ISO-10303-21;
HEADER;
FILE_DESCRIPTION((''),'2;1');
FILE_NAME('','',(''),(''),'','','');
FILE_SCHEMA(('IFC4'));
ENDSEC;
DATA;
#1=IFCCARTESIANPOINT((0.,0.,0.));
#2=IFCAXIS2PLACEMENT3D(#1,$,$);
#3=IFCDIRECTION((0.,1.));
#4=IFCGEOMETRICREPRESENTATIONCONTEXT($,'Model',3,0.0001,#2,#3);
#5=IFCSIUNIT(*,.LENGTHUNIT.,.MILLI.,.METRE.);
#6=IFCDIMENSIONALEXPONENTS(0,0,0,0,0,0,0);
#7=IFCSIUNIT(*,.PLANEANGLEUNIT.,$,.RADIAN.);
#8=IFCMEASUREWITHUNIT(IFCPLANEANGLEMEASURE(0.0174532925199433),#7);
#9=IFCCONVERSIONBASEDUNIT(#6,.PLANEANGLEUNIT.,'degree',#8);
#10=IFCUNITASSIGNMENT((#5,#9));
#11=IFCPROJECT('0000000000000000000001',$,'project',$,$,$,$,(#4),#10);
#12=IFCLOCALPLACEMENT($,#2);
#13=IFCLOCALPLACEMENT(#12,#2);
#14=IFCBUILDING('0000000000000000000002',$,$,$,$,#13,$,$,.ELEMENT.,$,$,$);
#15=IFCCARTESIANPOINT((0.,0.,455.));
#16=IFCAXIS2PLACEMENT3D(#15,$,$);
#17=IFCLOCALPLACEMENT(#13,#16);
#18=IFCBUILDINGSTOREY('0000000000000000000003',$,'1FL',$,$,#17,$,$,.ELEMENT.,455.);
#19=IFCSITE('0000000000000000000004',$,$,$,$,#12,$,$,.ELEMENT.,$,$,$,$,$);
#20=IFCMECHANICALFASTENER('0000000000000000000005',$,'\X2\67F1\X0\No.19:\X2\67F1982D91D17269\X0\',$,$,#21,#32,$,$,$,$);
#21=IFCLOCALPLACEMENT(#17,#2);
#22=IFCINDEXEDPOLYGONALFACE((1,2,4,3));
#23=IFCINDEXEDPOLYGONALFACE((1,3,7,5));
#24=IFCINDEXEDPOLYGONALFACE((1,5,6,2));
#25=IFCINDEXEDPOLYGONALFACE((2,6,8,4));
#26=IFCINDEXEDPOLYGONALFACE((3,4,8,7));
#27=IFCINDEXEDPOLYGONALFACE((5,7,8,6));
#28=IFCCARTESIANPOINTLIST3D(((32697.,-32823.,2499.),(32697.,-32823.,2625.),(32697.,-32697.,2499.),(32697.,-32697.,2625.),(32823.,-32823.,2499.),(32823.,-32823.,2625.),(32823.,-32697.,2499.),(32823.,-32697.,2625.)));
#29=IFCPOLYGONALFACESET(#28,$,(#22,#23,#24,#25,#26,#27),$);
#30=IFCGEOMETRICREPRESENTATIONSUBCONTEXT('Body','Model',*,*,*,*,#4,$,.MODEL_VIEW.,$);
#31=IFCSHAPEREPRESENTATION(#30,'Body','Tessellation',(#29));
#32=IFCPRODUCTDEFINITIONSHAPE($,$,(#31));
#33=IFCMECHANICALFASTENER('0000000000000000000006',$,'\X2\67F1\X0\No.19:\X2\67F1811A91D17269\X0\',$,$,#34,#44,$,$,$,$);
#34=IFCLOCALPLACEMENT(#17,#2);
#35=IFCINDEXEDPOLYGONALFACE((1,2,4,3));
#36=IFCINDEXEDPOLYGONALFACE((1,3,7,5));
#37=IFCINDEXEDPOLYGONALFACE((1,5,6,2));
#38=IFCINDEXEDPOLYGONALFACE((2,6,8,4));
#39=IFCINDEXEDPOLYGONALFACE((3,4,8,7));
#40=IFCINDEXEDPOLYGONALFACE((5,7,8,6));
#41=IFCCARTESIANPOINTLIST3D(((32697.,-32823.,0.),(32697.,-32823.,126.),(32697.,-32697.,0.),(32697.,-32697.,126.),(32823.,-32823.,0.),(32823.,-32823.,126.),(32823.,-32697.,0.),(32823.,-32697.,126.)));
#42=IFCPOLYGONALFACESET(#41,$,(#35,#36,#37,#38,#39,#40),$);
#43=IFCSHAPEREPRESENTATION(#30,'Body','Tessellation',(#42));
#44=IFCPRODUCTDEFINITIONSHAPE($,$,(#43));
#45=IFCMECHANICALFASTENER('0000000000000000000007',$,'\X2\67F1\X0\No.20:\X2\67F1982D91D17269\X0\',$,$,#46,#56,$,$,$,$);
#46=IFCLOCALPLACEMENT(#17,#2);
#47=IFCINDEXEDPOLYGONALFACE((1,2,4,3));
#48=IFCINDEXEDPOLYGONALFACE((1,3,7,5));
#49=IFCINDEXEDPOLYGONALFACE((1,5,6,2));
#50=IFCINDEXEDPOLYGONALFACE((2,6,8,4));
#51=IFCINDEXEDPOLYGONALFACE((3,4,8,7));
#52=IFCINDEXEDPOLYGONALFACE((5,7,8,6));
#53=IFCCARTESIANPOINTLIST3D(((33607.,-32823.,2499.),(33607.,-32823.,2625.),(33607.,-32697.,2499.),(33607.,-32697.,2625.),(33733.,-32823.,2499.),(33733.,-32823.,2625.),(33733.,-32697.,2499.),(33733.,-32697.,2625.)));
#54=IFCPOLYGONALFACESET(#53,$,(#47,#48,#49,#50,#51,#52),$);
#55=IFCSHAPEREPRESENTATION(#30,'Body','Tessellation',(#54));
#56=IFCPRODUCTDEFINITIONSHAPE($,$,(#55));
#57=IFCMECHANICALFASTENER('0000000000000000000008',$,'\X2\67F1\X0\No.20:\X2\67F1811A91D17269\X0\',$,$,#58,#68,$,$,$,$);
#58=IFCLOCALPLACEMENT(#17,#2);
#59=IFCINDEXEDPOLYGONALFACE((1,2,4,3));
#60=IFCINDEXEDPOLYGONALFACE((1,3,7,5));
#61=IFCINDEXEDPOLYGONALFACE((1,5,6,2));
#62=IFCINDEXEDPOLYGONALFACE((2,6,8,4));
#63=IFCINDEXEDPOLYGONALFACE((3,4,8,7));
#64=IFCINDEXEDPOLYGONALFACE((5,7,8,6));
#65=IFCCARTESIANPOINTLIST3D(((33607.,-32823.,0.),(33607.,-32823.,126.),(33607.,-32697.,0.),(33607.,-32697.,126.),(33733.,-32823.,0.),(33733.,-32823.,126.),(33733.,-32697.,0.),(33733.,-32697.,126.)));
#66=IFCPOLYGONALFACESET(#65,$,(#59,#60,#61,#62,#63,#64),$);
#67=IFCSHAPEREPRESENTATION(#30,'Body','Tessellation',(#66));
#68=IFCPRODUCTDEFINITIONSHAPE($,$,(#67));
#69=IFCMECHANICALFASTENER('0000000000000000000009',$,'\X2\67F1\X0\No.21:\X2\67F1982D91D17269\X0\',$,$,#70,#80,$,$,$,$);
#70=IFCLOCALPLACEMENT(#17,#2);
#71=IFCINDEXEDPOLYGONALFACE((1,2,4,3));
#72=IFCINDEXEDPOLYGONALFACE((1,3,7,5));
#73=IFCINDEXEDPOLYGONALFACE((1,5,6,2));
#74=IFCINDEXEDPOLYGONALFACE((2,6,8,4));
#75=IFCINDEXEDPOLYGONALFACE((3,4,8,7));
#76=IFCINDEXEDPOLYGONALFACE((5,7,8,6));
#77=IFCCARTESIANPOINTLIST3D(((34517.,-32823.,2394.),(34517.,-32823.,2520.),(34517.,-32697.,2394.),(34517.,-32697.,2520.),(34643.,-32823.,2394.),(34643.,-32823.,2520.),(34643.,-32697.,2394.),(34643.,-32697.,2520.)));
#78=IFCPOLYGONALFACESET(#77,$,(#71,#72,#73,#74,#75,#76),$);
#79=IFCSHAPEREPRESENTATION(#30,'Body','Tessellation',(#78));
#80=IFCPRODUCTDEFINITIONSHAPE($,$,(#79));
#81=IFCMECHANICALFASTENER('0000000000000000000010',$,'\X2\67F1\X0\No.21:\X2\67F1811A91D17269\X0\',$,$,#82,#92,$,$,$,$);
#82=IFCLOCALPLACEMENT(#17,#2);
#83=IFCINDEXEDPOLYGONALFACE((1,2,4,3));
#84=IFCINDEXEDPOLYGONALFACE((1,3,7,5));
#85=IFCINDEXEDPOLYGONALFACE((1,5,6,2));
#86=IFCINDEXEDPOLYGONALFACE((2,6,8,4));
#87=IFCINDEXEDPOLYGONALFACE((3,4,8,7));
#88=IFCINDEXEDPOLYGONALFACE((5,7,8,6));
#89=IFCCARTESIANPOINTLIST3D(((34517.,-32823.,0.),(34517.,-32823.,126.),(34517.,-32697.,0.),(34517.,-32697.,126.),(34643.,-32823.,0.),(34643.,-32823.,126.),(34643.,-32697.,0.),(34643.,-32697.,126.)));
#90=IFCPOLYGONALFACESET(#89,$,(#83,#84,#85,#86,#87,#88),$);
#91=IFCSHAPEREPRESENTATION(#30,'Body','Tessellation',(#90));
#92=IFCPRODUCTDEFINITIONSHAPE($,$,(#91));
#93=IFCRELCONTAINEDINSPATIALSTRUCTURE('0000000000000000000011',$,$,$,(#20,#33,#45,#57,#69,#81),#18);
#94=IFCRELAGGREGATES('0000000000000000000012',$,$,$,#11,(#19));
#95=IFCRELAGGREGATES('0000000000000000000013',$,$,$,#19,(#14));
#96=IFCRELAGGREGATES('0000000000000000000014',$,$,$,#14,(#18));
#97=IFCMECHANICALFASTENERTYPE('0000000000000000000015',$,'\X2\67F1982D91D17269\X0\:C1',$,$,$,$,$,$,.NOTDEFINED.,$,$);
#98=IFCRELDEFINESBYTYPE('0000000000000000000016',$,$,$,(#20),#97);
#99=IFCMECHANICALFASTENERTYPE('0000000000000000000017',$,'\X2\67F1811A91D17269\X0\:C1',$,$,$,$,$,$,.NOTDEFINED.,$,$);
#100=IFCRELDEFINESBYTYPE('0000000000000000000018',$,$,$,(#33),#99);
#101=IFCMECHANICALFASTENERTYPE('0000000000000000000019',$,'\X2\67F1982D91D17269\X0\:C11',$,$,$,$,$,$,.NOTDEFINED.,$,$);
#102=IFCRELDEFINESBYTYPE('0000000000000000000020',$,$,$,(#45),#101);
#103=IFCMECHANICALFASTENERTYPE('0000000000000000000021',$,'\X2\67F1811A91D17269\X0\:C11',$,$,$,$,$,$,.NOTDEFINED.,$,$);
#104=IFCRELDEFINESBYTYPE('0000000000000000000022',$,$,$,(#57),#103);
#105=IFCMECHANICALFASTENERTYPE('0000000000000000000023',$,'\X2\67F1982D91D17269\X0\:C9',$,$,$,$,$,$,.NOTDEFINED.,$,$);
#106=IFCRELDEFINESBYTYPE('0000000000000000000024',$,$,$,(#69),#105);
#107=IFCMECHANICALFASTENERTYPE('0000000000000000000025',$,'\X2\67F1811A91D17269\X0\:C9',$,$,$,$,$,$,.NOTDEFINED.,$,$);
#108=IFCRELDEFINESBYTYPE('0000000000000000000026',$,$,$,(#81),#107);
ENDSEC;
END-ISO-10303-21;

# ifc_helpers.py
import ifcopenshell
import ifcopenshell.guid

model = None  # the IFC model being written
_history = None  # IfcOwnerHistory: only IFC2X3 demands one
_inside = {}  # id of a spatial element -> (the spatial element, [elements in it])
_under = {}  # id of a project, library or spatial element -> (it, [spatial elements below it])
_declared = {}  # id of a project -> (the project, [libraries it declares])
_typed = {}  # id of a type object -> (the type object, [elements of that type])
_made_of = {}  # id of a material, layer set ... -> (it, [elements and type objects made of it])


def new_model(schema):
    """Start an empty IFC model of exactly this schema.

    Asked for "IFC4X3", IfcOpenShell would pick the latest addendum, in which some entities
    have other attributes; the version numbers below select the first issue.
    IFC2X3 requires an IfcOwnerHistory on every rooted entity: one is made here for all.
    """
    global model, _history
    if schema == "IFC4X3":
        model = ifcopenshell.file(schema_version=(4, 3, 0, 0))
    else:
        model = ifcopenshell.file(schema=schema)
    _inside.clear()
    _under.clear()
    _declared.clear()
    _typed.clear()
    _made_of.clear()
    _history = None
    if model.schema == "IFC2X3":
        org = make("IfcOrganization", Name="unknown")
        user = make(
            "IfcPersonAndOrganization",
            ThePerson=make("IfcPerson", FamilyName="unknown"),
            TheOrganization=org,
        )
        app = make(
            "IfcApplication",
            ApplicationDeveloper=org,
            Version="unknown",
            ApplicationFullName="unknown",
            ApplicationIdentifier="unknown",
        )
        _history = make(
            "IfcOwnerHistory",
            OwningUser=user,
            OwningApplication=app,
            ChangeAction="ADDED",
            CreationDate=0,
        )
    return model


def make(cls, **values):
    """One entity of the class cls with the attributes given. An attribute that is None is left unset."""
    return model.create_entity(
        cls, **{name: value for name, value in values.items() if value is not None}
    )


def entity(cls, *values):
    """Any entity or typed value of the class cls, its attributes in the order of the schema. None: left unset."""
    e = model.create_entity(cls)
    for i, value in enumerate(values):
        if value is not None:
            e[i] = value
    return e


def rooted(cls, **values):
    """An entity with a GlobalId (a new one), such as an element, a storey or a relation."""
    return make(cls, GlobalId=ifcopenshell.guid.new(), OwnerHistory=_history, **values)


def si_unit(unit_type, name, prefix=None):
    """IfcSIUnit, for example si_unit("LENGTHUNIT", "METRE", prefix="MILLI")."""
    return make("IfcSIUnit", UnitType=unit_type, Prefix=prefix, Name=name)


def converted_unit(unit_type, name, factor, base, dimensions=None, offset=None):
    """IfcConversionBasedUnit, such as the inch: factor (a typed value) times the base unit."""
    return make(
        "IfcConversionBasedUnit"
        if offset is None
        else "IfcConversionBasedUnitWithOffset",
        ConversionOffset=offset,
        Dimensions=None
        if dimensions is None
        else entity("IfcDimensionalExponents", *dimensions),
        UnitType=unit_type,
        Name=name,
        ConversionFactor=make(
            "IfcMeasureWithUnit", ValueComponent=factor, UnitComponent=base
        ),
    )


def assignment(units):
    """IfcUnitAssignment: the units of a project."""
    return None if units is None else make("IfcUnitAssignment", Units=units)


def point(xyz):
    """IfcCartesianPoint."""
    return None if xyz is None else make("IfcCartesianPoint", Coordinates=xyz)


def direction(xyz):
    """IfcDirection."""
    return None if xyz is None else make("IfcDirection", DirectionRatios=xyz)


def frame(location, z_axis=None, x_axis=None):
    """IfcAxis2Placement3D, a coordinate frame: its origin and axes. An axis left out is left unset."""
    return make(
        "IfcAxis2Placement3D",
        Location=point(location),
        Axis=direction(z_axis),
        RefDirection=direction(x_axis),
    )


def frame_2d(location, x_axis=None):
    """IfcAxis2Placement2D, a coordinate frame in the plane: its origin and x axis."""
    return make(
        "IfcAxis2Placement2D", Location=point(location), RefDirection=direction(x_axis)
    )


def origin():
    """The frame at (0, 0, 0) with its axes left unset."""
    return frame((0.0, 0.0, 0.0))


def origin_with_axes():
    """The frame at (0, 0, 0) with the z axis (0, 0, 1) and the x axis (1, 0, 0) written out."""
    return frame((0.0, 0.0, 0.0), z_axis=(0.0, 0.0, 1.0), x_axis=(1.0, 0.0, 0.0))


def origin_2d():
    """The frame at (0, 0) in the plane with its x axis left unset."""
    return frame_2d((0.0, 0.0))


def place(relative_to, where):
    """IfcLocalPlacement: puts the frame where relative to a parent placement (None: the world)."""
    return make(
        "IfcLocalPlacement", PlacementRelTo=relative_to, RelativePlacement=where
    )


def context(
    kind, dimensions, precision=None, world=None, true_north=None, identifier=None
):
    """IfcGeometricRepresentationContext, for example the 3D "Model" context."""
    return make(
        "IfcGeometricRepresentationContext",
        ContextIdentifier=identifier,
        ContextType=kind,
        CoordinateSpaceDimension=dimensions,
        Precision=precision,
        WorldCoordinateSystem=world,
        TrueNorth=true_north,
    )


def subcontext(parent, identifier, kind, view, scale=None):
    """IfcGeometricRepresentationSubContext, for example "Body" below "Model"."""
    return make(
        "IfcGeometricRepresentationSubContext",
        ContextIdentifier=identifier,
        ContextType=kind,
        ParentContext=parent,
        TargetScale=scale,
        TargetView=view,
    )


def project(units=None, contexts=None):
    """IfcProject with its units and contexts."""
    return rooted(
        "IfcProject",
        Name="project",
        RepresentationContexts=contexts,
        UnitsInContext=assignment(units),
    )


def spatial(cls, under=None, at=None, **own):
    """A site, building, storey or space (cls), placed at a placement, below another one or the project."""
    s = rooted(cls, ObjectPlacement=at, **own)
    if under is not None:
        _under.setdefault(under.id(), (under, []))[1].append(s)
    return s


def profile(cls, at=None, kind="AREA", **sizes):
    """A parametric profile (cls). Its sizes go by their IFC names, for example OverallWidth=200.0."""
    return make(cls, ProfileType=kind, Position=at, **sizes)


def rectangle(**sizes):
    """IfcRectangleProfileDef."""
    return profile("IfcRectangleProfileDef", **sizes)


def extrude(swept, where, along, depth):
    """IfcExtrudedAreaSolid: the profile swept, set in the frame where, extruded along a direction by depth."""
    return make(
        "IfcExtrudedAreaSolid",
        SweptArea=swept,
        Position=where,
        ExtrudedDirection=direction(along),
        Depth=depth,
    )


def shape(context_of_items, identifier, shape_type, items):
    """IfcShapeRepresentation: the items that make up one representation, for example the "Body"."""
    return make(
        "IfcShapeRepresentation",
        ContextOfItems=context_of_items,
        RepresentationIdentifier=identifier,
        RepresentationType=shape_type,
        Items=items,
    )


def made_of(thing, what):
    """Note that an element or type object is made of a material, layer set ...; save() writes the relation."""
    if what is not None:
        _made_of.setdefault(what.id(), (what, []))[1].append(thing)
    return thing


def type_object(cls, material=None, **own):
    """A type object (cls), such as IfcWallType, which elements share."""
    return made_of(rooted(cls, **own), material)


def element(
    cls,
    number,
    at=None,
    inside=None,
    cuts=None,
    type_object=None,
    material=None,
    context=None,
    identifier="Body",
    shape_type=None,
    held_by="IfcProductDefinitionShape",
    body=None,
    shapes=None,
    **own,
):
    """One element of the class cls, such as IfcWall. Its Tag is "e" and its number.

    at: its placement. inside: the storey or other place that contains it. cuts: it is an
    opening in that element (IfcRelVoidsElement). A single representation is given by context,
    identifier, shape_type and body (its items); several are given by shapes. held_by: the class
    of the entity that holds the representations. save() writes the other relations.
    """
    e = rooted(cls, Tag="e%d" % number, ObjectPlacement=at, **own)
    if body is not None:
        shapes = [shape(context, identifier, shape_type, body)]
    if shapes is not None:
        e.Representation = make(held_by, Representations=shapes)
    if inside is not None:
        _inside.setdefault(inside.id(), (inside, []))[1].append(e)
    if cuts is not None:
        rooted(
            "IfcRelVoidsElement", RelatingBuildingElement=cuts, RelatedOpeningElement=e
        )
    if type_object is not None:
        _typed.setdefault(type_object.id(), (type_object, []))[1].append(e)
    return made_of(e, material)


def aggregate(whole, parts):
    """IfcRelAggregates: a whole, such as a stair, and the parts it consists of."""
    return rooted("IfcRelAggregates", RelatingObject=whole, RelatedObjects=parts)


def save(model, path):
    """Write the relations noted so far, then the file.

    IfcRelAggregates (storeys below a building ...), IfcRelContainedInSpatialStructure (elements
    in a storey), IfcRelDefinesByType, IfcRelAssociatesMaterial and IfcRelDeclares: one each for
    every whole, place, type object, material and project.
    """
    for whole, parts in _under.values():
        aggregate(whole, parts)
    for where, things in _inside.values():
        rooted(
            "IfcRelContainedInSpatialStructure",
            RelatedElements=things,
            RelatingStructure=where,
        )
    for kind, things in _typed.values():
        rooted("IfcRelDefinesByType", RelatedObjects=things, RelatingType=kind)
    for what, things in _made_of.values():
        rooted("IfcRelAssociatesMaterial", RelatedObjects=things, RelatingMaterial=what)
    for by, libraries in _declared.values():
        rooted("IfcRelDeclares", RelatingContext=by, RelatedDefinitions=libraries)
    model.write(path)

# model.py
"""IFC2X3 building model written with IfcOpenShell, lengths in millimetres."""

from ifc_helpers import new_model, entity, si_unit, converted_unit, direction, frame, origin, origin_with_axes, origin_2d, place, context, subcontext, project, spatial, rectangle, extrude, type_object, element, save


model = new_model("IFC2X3")

# Units and contexts
model_context = context("Model", 3, precision=0.0001, world=origin(), true_north=direction((0.0, 1.0)))
body_context = subcontext(model_context, "Body", "Model", "MODEL_VIEW")
ifc_project = project(units=[si_unit("LENGTHUNIT", "METRE", prefix="MILLI"), converted_unit("PLANEANGLEUNIT", "degree", entity("IfcPlaneAngleMeasure", 0.0174532925199433), si_unit("PLANEANGLEUNIT", "RADIAN"), dimensions=[0, 0, 0, 0, 0, 0, 0])], contexts=[model_context])

# Site, building, storey
site_placement = place(None, origin())
site = spatial("IfcSite", under=ifc_project, at=site_placement, CompositionType="ELEMENT")
building_placement = place(site_placement, origin())
building = spatial("IfcBuilding", under=site, at=building_placement, CompositionType="ELEMENT")
storey_placement = place(building_placement, frame((0.0, 0.0, 455.0)))
storey = spatial("IfcBuildingStorey", under=building, at=storey_placement, Name="1FL", CompositionType="ELEMENT", Elevation=455.0)

# Mechanical fasteners
mechanical_fastener_type_1 = type_object("IfcMechanicalFastenerType", Name="柱頭金物:C1")
mechanical_fastener_1_placement = place(storey_placement, frame((32760.0, -32760.0, 2499.0)))
element("IfcMechanicalFastener", 1, at=mechanical_fastener_1_placement, inside=storey, type_object=mechanical_fastener_type_1, Name="柱No.19:柱頭金物", context=body_context, shape_type="SweptSolid", body=[
    extrude(rectangle(XDim=126.0, YDim=126.0, at=origin_2d()), origin_with_axes(), (0.0, 0.0, 1.0), 126.0),
])
mechanical_fastener_type_2 = type_object("IfcMechanicalFastenerType", Name="柱脚金物:C1")
mechanical_fastener_2_placement = place(storey_placement, frame((32760.0, -32760.0, 0.0)))
element("IfcMechanicalFastener", 2, at=mechanical_fastener_2_placement, inside=storey, type_object=mechanical_fastener_type_2, Name="柱No.19:柱脚金物", context=body_context, shape_type="SweptSolid", body=[
    extrude(rectangle(XDim=126.0, YDim=126.0, at=origin_2d()), origin_with_axes(), (0.0, 0.0, 1.0), 126.0),
])
mechanical_fastener_type_3 = type_object("IfcMechanicalFastenerType", Name="柱頭金物:C11")
mechanical_fastener_3_placement = place(storey_placement, frame((33670.0, -32760.0, 2499.0)))
element("IfcMechanicalFastener", 3, at=mechanical_fastener_3_placement, inside=storey, type_object=mechanical_fastener_type_3, Name="柱No.20:柱頭金物", context=body_context, shape_type="SweptSolid", body=[
    extrude(rectangle(XDim=126.0, YDim=126.0, at=origin_2d()), origin_with_axes(), (0.0, 0.0, 1.0), 126.0),
])
mechanical_fastener_type_4 = type_object("IfcMechanicalFastenerType", Name="柱脚金物:C11")
mechanical_fastener_4_placement = place(storey_placement, frame((33670.0, -32760.0, 0.0)))
element("IfcMechanicalFastener", 4, at=mechanical_fastener_4_placement, inside=storey, type_object=mechanical_fastener_type_4, Name="柱No.20:柱脚金物", context=body_context, shape_type="SweptSolid", body=[
    extrude(rectangle(XDim=126.0, YDim=126.0, at=origin_2d()), origin_with_axes(), (0.0, 0.0, 1.0), 126.0),
])
mechanical_fastener_type_5 = type_object("IfcMechanicalFastenerType", Name="柱頭金物:C9")
mechanical_fastener_5_placement = place(storey_placement, frame((34580.0, -32760.0, 2394.0)))
element("IfcMechanicalFastener", 5, at=mechanical_fastener_5_placement, inside=storey, type_object=mechanical_fastener_type_5, Name="柱No.21:柱頭金物", context=body_context, shape_type="SweptSolid", body=[
    extrude(rectangle(XDim=126.0, YDim=126.0, at=origin_2d()), origin_with_axes(), (0.0, 0.0, 1.0), 126.0),
])
mechanical_fastener_type_6 = type_object("IfcMechanicalFastenerType", Name="柱脚金物:C9")
mechanical_fastener_6_placement = place(storey_placement, frame((34580.0, -32760.0, 0.0)))
element("IfcMechanicalFastener", 6, at=mechanical_fastener_6_placement, inside=storey, type_object=mechanical_fastener_type_6, Name="柱No.21:柱脚金物", context=body_context, shape_type="SweptSolid", body=[
    extrude(rectangle(XDim=126.0, YDim=126.0, at=origin_2d()), origin_with_axes(), (0.0, 0.0, 1.0), 126.0),
])

save(model, "model.ifc")
